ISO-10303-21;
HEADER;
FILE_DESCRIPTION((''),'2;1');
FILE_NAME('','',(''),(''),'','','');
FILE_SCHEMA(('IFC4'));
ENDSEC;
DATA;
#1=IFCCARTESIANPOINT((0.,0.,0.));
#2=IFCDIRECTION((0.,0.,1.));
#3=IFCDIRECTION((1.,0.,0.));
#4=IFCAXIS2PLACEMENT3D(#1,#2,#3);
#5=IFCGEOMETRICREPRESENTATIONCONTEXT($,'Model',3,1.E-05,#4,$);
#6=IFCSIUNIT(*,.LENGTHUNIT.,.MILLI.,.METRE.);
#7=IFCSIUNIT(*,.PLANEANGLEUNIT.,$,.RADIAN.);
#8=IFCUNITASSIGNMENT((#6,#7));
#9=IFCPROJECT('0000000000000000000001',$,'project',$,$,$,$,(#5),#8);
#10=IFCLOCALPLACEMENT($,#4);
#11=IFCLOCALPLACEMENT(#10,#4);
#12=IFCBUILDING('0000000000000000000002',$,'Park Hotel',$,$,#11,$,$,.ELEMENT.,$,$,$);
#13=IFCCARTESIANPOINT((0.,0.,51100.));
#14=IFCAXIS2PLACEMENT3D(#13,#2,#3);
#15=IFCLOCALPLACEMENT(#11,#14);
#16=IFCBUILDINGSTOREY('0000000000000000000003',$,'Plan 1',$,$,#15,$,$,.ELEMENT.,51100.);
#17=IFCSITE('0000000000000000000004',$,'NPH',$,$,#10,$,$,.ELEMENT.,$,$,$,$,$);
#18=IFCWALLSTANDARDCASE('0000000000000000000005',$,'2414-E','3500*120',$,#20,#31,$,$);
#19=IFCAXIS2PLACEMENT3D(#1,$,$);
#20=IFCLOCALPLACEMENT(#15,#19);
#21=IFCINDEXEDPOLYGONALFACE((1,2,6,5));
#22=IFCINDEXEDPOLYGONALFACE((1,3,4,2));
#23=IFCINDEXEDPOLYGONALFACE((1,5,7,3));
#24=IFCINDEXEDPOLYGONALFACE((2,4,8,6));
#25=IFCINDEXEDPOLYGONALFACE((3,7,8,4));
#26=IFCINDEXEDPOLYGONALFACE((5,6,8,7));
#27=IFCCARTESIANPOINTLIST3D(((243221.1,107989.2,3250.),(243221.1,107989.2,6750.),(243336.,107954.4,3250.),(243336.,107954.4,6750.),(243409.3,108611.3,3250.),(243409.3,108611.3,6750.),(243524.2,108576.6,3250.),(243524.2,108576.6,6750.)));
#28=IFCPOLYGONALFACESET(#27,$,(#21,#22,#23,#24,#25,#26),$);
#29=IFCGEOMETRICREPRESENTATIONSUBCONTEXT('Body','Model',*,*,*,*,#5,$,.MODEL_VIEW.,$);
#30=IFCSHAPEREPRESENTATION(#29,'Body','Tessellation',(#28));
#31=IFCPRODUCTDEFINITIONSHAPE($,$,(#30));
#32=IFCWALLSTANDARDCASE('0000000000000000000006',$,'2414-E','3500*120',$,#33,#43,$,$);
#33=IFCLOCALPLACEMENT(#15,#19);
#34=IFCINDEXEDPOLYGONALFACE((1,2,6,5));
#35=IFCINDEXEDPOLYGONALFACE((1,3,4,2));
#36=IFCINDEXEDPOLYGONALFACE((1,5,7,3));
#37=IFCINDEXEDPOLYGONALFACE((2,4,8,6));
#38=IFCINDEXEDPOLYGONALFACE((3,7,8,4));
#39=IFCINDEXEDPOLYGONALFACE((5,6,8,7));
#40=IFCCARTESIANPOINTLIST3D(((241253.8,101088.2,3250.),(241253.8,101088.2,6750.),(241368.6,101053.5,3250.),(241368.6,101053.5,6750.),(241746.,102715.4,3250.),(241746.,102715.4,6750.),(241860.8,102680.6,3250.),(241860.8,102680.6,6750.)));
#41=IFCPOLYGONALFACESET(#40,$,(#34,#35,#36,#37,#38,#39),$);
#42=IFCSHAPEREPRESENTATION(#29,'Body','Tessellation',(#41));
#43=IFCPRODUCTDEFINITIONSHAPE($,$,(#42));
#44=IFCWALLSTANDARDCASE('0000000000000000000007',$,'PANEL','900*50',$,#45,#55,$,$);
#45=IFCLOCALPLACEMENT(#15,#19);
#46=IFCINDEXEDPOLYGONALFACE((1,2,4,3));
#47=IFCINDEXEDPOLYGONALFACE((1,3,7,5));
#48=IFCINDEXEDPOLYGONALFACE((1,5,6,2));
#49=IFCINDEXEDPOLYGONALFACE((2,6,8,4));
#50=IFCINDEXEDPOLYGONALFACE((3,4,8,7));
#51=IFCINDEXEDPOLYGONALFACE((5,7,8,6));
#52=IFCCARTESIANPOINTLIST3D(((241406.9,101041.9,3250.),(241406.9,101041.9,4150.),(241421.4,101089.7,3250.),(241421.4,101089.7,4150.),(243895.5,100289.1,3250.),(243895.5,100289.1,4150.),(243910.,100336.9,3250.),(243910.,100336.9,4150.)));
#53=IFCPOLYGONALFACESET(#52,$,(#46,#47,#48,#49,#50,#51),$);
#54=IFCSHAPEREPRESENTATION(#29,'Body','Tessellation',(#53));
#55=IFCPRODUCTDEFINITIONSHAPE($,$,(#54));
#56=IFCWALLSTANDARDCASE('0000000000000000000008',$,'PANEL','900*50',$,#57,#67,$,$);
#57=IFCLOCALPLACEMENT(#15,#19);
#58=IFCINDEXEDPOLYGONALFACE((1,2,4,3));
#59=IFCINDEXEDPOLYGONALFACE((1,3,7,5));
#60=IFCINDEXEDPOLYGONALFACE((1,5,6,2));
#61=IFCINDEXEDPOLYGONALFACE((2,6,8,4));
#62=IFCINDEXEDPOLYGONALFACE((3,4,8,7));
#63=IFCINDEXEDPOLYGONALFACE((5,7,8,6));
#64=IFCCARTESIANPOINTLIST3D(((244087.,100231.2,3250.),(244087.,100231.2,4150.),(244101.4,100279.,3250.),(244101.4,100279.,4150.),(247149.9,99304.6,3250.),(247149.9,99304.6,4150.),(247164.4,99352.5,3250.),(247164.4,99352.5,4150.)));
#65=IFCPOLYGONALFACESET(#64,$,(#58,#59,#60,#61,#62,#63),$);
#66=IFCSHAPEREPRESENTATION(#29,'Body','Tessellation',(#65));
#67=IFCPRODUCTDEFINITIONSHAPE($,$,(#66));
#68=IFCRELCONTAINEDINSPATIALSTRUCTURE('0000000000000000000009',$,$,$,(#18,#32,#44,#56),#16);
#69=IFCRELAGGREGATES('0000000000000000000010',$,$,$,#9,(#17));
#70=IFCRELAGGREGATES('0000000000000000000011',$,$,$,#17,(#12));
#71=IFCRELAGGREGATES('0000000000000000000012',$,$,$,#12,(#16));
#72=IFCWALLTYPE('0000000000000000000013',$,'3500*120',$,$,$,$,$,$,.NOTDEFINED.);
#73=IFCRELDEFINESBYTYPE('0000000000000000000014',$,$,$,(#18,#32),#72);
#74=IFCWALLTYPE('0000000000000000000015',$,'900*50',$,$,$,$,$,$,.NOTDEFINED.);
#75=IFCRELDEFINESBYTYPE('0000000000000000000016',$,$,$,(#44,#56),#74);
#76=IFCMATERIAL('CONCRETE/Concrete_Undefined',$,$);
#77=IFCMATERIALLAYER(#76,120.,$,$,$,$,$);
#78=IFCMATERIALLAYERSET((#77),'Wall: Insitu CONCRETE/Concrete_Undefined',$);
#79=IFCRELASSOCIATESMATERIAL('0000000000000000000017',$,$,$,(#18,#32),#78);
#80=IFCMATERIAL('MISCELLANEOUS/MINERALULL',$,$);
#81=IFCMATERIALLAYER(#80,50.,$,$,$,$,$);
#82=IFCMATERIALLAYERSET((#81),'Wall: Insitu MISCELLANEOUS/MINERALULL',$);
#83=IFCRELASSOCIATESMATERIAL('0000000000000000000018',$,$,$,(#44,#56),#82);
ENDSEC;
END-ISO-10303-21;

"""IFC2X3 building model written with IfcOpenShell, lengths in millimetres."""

from ifc_helpers import new_model, si_unit, frame, frame_2d, origin_with_axes, place, context, subcontext, project, spatial, rectangle, extrude, material, layer, layer_set, layer_usage, type_object, element, save


model = new_model("IFC2X3")

# Units and contexts
model_context = context("Model", 3, precision=1e-05, world=origin_with_axes())
body_context = subcontext(model_context, "Body", "Model", "MODEL_VIEW")
ifc_project = project(units=[si_unit("LENGTHUNIT", "METRE", prefix="MILLI"), si_unit("PLANEANGLEUNIT", "RADIAN")], contexts=[model_context])

# Site, building, storey
site_placement = place(None, origin_with_axes())
site = spatial("IfcSite", under=ifc_project, at=site_placement, Name="NPH", CompositionType="ELEMENT")
building_placement = place(site_placement, origin_with_axes())
building = spatial("IfcBuilding", under=site, at=building_placement, Name="Park Hotel", CompositionType="ELEMENT")
storey_placement = place(building_placement, frame((0.0, 0.0, 51100.0), z_axis=(0.0, 0.0, 1.0), x_axis=(1.0, 0.0, 0.0)))
storey = spatial("IfcBuildingStorey", under=building, at=storey_placement, Name="Plan 1", CompositionType="ELEMENT", Elevation=51100.0)

# Shared definitions
ifc_material_1 = material(Name="CONCRETE/Concrete_Undefined")

# Walls
ifc_material_2 = material(Name="MISCELLANEOUS/MINERALULL")
ifc_layer_1 = layer(ifc_material_2, 50.0)
ifc_layer_set_1 = layer_set([ifc_layer_1], Name="Wall: Insitu MISCELLANEOUS/MINERALULL")
ifc_layer_2 = layer(ifc_material_1, 120.0)
ifc_layer_set_2 = layer_set([ifc_layer_2], Name="Wall: Insitu CONCRETE/Concrete_Undefined")
ifc_layer_usage_1 = layer_usage(ifc_layer_set_2, "AXIS2", "POSITIVE", -60.0)
wall_type_1 = type_object("IfcWallType", Name="3500*120", PredefinedType="NOTDEFINED")
wall_1_placement = place(storey_placement, frame((243466.7, 108593.9, 3250.0), z_axis=(0.0, 0.0, 1.0), x_axis=(-0.28955, -0.957163, 0.0)))
element("IfcWallStandardCase", 1, at=wall_1_placement, inside=storey, type_object=wall_type_1, material=ifc_layer_usage_1, Name="2414-E", Description="3500*120", context=body_context, shape_type="SweptSolid", body=[
    extrude(rectangle(XDim=650.0, YDim=120.0, at=frame_2d((0.0, 325.0), x_axis=(0.0, -1.0))), frame((0.0, 0.0, 0.0), z_axis=(0.0, 0.0, 1.0), x_axis=(0.0, -1.0, 0.0)), (0.0, 0.0, 1.0), 3500.0),
])
ifc_layer_usage_2 = layer_usage(ifc_layer_set_2, "AXIS2", "POSITIVE", -60.0)
wall_2_placement = place(storey_placement, frame((241803.4, 102698.0, 3250.0), z_axis=(0.0, 0.0, 1.0), x_axis=(-0.289542, -0.957165, 0.0)))
element("IfcWallStandardCase", 2, at=wall_2_placement, inside=storey, type_object=wall_type_1, material=ifc_layer_usage_2, Name="2414-E", Description="3500*120", context=body_context, shape_type="SweptSolid", body=[
    extrude(rectangle(XDim=1700.0, YDim=120.0, at=frame_2d((0.0, 850.0), x_axis=(0.0, -1.0))), frame((0.0, 0.0, 0.0), z_axis=(0.0, 0.0, 1.0), x_axis=(0.0, -1.0, 0.0)), (0.0, 0.0, 1.0), 3500.0),
])
ifc_layer_usage_3 = layer_usage(ifc_layer_set_1, "AXIS2", "POSITIVE", -25.0)
wall_type_2 = type_object("IfcWallType", Name="900*50", PredefinedType="NOTDEFINED")
wall_3_placement = place(storey_placement, frame((241414.1, 101065.8, 3250.0), z_axis=(0.0, 0.0, 1.0), x_axis=(0.957166, -0.289539, 0.0)))
element("IfcWallStandardCase", 3, at=wall_3_placement, inside=storey, type_object=wall_type_2, material=ifc_layer_usage_3, Name="PANEL", Description="900*50", context=body_context, shape_type="SweptSolid", body=[
    extrude(rectangle(XDim=2600.0, YDim=50.0, at=frame_2d((0.0, 1300.0), x_axis=(0.0, -1.0))), frame((0.0, 0.0, 0.0), z_axis=(0.0, 0.0, 1.0), x_axis=(0.0, -1.0, 0.0)), (0.0, 0.0, 1.0), 900.0),
])
ifc_layer_usage_4 = layer_usage(ifc_layer_set_1, "AXIS2", "POSITIVE", -25.0)
wall_4_placement = place(storey_placement, frame((244094.2, 100255.1, 3250.0), z_axis=(0.0, 0.0, 1.0), x_axis=(0.957166, -0.289539, 0.0)))
element("IfcWallStandardCase", 4, at=wall_4_placement, inside=storey, type_object=wall_type_2, material=ifc_layer_usage_4, Name="PANEL", Description="900*50", context=body_context, shape_type="SweptSolid", body=[
    extrude(rectangle(XDim=3200.0, YDim=50.0, at=frame_2d((0.0, 1600.0), x_axis=(0.0, -1.0))), frame((0.0, 0.0, 0.0), z_axis=(0.0, 0.0, 1.0), x_axis=(0.0, -1.0, 0.0)), (0.0, 0.0, 1.0), 900.0),
])

save(model, "model.ifc")
